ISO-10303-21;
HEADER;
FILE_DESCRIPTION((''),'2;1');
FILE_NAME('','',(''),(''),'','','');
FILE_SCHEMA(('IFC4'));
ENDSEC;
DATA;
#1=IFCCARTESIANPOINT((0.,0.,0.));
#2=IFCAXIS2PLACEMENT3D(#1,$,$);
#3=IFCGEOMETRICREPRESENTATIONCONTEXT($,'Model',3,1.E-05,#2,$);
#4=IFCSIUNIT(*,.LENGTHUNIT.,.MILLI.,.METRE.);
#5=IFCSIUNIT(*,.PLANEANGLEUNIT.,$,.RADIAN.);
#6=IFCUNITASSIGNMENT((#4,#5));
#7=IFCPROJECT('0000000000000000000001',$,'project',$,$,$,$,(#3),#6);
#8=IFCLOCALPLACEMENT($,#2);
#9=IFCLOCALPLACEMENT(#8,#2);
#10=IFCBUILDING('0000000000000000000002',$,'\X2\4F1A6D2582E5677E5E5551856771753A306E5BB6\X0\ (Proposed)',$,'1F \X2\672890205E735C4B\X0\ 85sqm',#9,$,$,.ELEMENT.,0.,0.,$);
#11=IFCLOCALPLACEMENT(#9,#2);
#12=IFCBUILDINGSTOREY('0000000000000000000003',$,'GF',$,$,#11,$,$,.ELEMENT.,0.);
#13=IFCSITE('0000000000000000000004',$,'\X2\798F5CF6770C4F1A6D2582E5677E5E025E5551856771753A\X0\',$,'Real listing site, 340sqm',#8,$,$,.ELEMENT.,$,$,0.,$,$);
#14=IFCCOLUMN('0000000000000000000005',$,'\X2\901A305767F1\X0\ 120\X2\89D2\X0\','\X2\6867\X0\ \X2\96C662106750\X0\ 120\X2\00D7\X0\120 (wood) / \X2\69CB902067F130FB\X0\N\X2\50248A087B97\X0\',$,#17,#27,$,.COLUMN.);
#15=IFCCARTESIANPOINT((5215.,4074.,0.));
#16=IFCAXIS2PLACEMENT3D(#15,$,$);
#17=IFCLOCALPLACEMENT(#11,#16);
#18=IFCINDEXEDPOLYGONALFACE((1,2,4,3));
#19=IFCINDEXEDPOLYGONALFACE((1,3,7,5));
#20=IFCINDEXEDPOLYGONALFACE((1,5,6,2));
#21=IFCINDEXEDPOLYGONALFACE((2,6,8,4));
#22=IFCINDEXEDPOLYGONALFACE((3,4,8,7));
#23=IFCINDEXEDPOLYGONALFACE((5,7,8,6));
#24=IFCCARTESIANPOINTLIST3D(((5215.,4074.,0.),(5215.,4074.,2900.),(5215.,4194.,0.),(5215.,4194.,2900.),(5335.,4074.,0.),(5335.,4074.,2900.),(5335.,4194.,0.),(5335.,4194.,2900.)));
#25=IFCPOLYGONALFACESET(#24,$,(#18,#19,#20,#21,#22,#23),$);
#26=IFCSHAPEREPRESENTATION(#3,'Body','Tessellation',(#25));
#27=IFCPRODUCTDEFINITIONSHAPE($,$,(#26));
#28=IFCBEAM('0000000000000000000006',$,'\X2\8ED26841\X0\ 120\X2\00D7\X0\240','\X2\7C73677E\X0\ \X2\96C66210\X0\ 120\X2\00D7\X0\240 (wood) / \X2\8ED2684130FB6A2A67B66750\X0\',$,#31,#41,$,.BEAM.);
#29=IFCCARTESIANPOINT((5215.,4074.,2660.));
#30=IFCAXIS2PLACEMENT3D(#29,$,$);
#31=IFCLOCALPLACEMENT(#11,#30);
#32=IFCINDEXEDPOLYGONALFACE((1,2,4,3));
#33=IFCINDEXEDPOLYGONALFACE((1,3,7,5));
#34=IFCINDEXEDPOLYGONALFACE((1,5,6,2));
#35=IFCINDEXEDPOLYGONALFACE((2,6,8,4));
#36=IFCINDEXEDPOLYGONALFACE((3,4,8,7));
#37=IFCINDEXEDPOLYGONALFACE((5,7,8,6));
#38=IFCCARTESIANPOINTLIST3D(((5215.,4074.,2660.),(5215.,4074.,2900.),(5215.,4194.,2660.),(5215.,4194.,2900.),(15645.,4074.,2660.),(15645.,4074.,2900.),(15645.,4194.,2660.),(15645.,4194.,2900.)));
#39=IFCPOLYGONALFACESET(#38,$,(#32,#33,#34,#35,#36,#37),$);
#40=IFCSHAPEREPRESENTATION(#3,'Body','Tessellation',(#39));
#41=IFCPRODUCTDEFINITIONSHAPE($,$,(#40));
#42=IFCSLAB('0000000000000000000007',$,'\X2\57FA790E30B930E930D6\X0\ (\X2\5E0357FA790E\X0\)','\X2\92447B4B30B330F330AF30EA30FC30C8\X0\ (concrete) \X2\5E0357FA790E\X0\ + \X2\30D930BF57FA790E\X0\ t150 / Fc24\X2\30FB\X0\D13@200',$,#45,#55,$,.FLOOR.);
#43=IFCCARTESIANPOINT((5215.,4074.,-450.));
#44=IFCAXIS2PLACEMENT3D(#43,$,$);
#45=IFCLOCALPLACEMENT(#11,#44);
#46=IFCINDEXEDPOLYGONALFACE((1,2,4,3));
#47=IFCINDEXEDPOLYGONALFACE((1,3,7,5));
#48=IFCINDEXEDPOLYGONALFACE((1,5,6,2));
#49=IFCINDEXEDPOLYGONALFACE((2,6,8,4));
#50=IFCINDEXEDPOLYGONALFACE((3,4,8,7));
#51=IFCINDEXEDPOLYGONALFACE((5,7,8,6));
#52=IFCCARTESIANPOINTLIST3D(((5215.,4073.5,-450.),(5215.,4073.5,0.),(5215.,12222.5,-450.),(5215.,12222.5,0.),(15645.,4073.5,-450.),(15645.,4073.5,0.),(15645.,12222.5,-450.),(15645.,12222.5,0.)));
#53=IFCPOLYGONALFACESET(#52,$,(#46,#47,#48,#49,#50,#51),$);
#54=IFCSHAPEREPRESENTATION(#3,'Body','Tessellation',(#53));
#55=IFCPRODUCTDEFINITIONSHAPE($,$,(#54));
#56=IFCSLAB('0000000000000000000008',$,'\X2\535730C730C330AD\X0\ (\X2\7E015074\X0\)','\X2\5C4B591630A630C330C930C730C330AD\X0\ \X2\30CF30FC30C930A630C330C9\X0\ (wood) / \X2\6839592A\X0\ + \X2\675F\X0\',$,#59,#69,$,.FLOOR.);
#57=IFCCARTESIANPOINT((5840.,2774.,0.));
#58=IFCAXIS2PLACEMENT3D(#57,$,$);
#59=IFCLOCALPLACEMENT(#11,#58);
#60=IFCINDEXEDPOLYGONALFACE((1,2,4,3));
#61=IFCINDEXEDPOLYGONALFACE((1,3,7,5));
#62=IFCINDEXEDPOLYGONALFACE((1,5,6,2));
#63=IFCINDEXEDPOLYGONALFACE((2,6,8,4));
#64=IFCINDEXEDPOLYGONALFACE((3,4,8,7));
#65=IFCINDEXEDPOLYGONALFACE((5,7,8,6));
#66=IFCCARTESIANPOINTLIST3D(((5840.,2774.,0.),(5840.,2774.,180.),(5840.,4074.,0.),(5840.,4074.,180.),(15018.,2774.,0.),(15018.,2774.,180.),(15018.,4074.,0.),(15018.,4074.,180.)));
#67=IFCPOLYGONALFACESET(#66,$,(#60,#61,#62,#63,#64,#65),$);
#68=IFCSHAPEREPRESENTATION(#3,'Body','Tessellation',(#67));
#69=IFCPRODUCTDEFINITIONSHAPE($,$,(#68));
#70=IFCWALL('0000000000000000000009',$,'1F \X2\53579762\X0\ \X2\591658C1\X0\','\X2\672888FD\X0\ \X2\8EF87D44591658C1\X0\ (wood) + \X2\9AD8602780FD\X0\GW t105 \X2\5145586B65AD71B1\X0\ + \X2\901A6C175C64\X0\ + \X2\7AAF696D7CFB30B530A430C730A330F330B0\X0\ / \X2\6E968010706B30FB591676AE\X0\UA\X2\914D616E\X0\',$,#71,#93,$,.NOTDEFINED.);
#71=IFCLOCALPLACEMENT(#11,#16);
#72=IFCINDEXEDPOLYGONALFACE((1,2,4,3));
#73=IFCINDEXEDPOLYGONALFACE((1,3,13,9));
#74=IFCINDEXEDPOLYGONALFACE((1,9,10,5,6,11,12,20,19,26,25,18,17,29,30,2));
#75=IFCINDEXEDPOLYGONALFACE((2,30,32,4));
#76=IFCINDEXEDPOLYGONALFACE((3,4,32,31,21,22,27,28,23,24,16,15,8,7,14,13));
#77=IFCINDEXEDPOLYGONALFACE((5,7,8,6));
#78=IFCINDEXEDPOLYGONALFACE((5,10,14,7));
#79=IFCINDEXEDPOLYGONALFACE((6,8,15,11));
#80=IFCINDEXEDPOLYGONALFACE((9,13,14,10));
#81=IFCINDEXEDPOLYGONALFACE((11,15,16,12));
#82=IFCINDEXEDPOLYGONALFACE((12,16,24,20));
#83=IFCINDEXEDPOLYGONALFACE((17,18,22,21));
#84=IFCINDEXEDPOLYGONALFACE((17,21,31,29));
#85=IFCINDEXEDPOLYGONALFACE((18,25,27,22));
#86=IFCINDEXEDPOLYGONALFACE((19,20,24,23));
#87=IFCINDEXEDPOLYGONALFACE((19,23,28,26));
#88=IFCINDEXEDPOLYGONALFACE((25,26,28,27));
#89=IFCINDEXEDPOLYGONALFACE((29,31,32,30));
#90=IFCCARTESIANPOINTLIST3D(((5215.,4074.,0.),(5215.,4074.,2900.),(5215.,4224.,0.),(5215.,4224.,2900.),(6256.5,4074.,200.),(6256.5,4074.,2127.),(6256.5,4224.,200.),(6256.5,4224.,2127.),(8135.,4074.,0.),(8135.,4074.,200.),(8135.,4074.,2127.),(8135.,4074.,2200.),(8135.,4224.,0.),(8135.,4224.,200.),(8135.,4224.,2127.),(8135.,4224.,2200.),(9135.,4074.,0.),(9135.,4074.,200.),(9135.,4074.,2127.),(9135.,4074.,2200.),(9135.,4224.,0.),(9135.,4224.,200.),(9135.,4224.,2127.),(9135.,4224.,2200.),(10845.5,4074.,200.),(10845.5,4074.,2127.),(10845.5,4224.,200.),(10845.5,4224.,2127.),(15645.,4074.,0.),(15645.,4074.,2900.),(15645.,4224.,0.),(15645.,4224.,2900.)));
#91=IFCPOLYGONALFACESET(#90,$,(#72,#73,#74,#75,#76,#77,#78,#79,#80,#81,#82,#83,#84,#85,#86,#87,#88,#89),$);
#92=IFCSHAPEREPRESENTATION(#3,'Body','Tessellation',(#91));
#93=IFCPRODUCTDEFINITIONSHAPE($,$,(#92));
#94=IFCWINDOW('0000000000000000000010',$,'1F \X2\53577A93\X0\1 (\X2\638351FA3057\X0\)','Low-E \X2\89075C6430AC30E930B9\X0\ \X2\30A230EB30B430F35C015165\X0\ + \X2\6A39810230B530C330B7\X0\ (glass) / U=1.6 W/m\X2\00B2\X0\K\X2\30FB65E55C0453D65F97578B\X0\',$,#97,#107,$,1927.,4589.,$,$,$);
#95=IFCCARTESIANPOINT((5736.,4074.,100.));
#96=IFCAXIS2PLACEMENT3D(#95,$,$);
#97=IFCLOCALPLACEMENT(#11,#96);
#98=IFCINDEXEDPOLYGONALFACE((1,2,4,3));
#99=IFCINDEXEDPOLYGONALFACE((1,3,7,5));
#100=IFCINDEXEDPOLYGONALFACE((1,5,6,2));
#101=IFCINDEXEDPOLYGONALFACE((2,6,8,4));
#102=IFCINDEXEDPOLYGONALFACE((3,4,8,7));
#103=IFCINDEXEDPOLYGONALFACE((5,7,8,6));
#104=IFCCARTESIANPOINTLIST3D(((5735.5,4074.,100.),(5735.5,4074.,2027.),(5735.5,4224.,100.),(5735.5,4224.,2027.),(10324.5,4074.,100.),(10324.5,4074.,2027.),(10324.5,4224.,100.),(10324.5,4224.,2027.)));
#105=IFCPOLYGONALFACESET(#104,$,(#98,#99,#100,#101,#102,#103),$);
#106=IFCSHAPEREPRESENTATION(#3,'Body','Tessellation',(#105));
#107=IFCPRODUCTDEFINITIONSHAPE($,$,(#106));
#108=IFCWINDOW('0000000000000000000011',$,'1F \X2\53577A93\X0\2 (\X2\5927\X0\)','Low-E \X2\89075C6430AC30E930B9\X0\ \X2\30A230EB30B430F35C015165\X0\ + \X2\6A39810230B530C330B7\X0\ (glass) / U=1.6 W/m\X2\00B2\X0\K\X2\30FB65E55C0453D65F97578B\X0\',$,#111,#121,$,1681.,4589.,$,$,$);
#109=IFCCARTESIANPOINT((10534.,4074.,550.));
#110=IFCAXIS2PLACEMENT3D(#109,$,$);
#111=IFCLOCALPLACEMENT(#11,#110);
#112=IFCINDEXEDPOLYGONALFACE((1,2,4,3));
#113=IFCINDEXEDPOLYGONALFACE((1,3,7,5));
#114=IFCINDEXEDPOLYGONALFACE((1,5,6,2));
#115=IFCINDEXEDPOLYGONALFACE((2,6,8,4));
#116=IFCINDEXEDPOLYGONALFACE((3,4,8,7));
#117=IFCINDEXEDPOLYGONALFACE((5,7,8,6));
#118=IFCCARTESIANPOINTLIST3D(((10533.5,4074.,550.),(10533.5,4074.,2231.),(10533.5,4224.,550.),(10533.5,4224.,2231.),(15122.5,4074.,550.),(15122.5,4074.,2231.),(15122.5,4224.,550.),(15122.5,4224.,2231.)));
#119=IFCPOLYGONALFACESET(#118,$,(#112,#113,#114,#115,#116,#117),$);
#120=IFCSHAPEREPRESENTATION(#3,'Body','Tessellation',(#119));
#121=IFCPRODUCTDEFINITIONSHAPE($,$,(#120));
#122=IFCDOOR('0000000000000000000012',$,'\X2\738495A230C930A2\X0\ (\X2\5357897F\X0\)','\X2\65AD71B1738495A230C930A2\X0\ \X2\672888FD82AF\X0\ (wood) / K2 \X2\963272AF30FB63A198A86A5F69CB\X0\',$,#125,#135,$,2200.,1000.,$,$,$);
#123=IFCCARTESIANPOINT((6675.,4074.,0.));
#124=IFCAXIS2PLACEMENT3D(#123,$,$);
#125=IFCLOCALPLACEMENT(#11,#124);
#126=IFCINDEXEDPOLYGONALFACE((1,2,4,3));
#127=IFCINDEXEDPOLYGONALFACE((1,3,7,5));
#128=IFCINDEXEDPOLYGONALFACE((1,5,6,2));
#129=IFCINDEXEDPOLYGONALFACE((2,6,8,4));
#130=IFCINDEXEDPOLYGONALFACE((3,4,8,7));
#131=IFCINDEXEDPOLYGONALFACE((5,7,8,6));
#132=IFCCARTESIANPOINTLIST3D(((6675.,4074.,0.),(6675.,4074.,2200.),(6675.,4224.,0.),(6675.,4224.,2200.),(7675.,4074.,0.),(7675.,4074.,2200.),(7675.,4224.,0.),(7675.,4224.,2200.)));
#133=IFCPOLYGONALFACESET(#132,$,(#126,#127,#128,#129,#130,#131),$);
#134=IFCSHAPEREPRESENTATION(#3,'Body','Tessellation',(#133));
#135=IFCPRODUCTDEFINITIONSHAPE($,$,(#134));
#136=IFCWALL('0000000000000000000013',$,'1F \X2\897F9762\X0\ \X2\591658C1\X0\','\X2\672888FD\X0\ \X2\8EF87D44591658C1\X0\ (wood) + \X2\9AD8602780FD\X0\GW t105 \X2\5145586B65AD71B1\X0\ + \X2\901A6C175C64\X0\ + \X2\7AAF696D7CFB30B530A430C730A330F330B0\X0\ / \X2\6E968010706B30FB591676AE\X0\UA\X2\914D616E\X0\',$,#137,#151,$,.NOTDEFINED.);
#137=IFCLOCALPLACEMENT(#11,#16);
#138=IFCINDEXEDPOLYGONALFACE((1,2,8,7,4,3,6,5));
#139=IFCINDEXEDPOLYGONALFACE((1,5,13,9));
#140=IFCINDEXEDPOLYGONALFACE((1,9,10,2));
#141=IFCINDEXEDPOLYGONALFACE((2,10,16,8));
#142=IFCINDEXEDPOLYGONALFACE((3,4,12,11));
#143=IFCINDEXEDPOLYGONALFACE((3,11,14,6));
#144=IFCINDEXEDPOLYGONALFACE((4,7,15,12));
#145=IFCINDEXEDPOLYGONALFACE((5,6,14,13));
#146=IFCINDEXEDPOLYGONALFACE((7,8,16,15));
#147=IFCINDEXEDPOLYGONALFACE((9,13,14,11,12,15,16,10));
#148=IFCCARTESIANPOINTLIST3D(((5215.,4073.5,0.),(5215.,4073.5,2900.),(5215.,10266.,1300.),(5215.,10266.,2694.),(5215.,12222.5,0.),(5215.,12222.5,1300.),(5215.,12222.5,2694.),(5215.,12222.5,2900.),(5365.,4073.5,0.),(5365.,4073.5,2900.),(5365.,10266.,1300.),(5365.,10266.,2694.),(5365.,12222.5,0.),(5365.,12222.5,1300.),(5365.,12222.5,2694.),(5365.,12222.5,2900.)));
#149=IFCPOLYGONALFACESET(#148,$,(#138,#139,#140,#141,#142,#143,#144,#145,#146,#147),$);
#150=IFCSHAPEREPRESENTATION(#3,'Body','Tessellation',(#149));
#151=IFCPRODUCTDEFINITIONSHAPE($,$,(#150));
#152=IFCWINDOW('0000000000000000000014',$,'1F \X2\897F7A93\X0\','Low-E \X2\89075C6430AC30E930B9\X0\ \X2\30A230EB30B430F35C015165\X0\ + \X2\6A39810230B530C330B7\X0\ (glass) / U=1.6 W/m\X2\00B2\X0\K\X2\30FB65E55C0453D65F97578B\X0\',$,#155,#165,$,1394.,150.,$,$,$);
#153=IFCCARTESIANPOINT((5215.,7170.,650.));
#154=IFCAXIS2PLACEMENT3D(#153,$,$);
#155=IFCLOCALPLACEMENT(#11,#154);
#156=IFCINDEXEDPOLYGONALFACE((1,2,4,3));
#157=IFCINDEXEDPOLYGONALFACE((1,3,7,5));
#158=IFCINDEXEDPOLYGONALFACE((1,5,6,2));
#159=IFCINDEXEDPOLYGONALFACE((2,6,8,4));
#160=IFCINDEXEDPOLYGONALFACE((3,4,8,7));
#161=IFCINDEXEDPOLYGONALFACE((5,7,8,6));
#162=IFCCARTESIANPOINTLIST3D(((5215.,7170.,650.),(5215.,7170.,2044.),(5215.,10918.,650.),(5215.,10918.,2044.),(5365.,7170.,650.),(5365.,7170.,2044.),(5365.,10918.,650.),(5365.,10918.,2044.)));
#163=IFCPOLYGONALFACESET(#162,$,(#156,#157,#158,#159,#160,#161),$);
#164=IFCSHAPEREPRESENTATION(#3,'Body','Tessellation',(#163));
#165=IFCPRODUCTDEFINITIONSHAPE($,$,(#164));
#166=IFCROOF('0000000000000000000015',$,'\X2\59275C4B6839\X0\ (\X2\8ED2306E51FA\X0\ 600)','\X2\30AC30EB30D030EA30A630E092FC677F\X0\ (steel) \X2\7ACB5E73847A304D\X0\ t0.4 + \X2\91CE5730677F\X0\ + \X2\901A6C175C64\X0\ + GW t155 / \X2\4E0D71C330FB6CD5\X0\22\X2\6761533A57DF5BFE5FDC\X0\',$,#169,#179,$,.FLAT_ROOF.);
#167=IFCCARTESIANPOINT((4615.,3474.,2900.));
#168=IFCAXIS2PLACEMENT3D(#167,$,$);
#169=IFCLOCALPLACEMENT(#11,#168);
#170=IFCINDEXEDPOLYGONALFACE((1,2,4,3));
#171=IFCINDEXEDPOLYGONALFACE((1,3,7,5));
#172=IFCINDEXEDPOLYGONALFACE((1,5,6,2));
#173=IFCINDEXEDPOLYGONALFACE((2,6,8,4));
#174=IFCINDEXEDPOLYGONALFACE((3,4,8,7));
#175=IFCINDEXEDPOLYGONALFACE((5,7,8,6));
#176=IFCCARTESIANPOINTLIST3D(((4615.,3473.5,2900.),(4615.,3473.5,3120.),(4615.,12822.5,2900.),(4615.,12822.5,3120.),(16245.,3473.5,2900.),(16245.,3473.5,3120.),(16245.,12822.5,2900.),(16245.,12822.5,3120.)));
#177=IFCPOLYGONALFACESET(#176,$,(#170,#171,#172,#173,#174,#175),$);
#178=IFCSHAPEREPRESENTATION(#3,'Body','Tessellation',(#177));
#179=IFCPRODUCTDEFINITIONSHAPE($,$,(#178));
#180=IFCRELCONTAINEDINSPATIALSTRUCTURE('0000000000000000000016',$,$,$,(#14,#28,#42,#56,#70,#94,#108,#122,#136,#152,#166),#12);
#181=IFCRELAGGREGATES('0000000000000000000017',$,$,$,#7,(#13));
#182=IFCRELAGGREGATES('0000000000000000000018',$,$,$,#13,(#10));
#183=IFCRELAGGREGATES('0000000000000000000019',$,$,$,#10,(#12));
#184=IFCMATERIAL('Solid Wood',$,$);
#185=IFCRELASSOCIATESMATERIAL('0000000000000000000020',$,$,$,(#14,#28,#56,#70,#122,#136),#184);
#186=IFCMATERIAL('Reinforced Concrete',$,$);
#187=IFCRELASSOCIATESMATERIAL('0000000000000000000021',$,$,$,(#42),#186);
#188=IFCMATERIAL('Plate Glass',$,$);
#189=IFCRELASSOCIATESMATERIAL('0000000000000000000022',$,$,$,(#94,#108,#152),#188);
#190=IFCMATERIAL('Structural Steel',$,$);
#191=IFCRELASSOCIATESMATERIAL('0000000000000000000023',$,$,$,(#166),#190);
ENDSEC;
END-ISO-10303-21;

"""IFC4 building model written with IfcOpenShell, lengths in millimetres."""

from ifc_helpers import new_model, si_unit, frame, frame_2d, origin, place, context, project, spatial, rectangle, extrude, material, element, fill, save


model = new_model("IFC4")

# Units and contexts
model_context = context("Model", 3, precision=1e-05, world=origin())
ifc_project = project(units=[si_unit("LENGTHUNIT", "METRE", prefix="MILLI"), si_unit("PLANEANGLEUNIT", "RADIAN")], contexts=[model_context])

# Site, building, storey
site_placement = place(None, origin())
site = spatial("IfcSite", under=ifc_project, at=site_placement, Name="福島県会津若松市幕内東町", ObjectType="Real listing site, 340sqm", CompositionType="ELEMENT", RefElevation=0.0)
building_placement = place(site_placement, origin())
building = spatial("IfcBuilding", under=site, at=building_placement, Name="会津若松幕内東町の家 (Proposed)", ObjectType="1F 木造平屋 85sqm", CompositionType="ELEMENT", ElevationOfRefHeight=0.0, ElevationOfTerrain=0.0)
storey_placement = place(building_placement, origin())
storey = spatial("IfcBuildingStorey", under=building, at=storey_placement, Name="GF", CompositionType="ELEMENT", Elevation=0.0)

# Column
ifc_material_1 = material(Name="Solid Wood")
column_1_placement = place(storey_placement, frame((5215.0, 4074.0, 0.0)))
element("IfcColumn", 1, at=column_1_placement, inside=storey, material=ifc_material_1, Name="通し柱 120角", Description="桧 集成材 120×120 (wood) / 構造柱・N値計算", PredefinedType="COLUMN", context=model_context, shape_type="SweptSolid", body=[
    extrude(rectangle(XDim=120.0, YDim=120.0, at=frame_2d((60.0, 60.0))), frame((5215.0, 4074.0, 0.0)), (0.0, 0.0, 1.0), 2900.0),
])

# Beam
beam_1_placement = place(storey_placement, frame((5215.0, 4074.0, 2660.0)))
element("IfcBeam", 2, at=beam_1_placement, inside=storey, material=ifc_material_1, Name="軒桁 120×240", Description="米松 集成 120×240 (wood) / 軒桁・横架材", PredefinedType="BEAM", context=model_context, shape_type="SweptSolid", body=[
    extrude(rectangle(XDim=10430.0, YDim=120.0, at=frame_2d((5215.0, 60.0))), frame((5215.0, 4074.0, 2660.0)), (0.0, 0.0, 1.0), 240.0),
])

# Slabs
ifc_material_2 = material(Name="Reinforced Concrete")
slab_1_placement = place(storey_placement, frame((5215.0, 4074.0, -450.0)))
element("IfcSlab", 3, at=slab_1_placement, inside=storey, material=ifc_material_2, Name="基礎スラブ (布基礎)", Description="鉄筋コンクリート (concrete) 布基礎 + ベタ基礎 t150 / Fc24・D13@200", PredefinedType="FLOOR", context=model_context, shape_type="SweptSolid", body=[
    extrude(rectangle(XDim=10430.0, YDim=8149.0, at=frame_2d((5215.0, 4074.0))), frame((5215.0, 4074.0, -450.0)), (0.0, 0.0, 1.0), 450.0),
])
slab_2_placement = place(storey_placement, frame((5840.0, 2774.0, 0.0)))
element("IfcSlab", 4, at=slab_2_placement, inside=storey, material=ifc_material_1, Name="南デッキ (縁側)", Description="屋外ウッドデッキ ハードウッド (wood) / 根太 + 束", PredefinedType="FLOOR", context=model_context, shape_type="SweptSolid", body=[
    extrude(rectangle(XDim=9178.0, YDim=1300.0, at=frame_2d((4589.0, 650.0))), frame((5840.0, 2774.0, 0.0)), (0.0, 0.0, 1.0), 180.0),
])

# Wall, openings, windows, door
wall_1_placement = place(storey_placement, frame((5215.0, 4074.0, 0.0)))
wall_1 = element("IfcWall", 5, at=wall_1_placement, inside=storey, material=ifc_material_1, Name="1F 南面 外壁", Description="木製 軸組外壁 (wood) + 高性能GW t105 充填断熱 + 通気層 + 窯業系サイディング / 準耐火・外皮UA配慮", PredefinedType="NOTDEFINED", context=model_context, shape_type="SweptSolid", body=[
    extrude(rectangle(XDim=10430.0, YDim=150.0, at=frame_2d((5215.0, 75.0))), frame((5215.0, 4074.0, 0.0)), (0.0, 0.0, 1.0), 2900.0),
])
opening_1_placement = place(storey_placement, frame((5736.0, 4074.0, 100.0)))
opening_1 = element("IfcOpeningElement", 6, at=opening_1_placement, cuts=wall_1, PredefinedType="NOTDEFINED", context=model_context, shape_type="SweptSolid", body=[
    extrude(rectangle(XDim=4589.0, YDim=150.0, at=frame_2d((2294.0, 75.0))), frame((5736.0, 4074.0, 100.0)), (0.0, 0.0, 1.0), 1927.0),
])
opening_2_placement = place(storey_placement, frame((10534.0, 4074.0, 550.0)))
opening_2 = element("IfcOpeningElement", 7, at=opening_2_placement, cuts=wall_1, PredefinedType="NOTDEFINED", context=model_context, shape_type="SweptSolid", body=[
    extrude(rectangle(XDim=4589.0, YDim=150.0, at=frame_2d((2294.0, 75.0))), frame((10534.0, 4074.0, 550.0)), (0.0, 0.0, 1.0), 1681.0),
])
opening_3_placement = place(storey_placement, frame((6675.0, 4074.0, 0.0)))
opening_3 = element("IfcOpeningElement", 8, at=opening_3_placement, cuts=wall_1, PredefinedType="NOTDEFINED", context=model_context, shape_type="SweptSolid", body=[
    extrude(rectangle(XDim=1000.0, YDim=150.0, at=frame_2d((500.0, 75.0))), frame((6675.0, 4074.0, 0.0)), (0.0, 0.0, 1.0), 2200.0),
])
ifc_material_3 = material(Name="Plate Glass")
window_1_placement = place(storey_placement, frame((5736.0, 4074.0, 100.0)))
window_1 = element("IfcWindow", 9, at=window_1_placement, inside=storey, material=ifc_material_3, Name="1F 南窓1 (掃出し)", Description="Low-E 複層ガラス アルゴン封入 + 樹脂サッシ (glass) / U=1.6 W/m²K・日射取得型", OverallHeight=1927.0, OverallWidth=4589.0, context=model_context, shape_type="SweptSolid", body=[
    extrude(rectangle(XDim=4589.0, YDim=150.0, at=frame_2d((2294.0, 75.0))), frame((5736.0, 4074.0, 100.0)), (0.0, 0.0, 1.0), 1927.0),
])
fill(opening_1, window_1)
window_2_placement = place(storey_placement, frame((10534.0, 4074.0, 550.0)))
window_2 = element("IfcWindow", 10, at=window_2_placement, inside=storey, material=ifc_material_3, Name="1F 南窓2 (大)", Description="Low-E 複層ガラス アルゴン封入 + 樹脂サッシ (glass) / U=1.6 W/m²K・日射取得型", OverallHeight=1681.0, OverallWidth=4589.0, context=model_context, shape_type="SweptSolid", body=[
    extrude(rectangle(XDim=4589.0, YDim=150.0, at=frame_2d((2294.0, 75.0))), frame((10534.0, 4074.0, 550.0)), (0.0, 0.0, 1.0), 1681.0),
])
fill(opening_2, window_2)
door_placement = place(storey_placement, frame((6675.0, 4074.0, 0.0)))
door = element("IfcDoor", 11, at=door_placement, inside=storey, material=ifc_material_1, Name="玄関ドア (南西)", Description="断熱玄関ドア 木製芯 (wood) / K2 防犯・採風機構", OverallHeight=2200.0, OverallWidth=1000.0, context=model_context, shape_type="SweptSolid", body=[
    extrude(rectangle(XDim=1000.0, YDim=150.0, at=frame_2d((500.0, 75.0))), frame((6675.0, 4074.0, 0.0)), (0.0, 0.0, 1.0), 2200.0),
])
fill(opening_3, door)

# Wall, opening, window
wall_2_placement = place(storey_placement, frame((5215.0, 4074.0, 0.0)))
wall_2 = element("IfcWall", 12, at=wall_2_placement, inside=storey, material=ifc_material_1, Name="1F 西面 外壁", Description="木製 軸組外壁 (wood) + 高性能GW t105 充填断熱 + 通気層 + 窯業系サイディング / 準耐火・外皮UA配慮", PredefinedType="NOTDEFINED", context=model_context, shape_type="SweptSolid", body=[
    extrude(rectangle(XDim=150.0, YDim=8149.0, at=frame_2d((75.0, 4074.0))), frame((5215.0, 4074.0, 0.0)), (0.0, 0.0, 1.0), 2900.0),
])
opening_4_placement = place(storey_placement, frame((5215.0, 7170.0, 650.0)))
opening_4 = element("IfcOpeningElement", 13, at=opening_4_placement, cuts=wall_2, PredefinedType="NOTDEFINED", context=model_context, shape_type="SweptSolid", body=[
    extrude(rectangle(XDim=150.0, YDim=3748.0, at=frame_2d((75.0, 1874.0))), frame((5215.0, 7170.0, 650.0)), (0.0, 0.0, 1.0), 1394.0),
])
window_3_placement = place(storey_placement, frame((5215.0, 7170.0, 650.0)))
window_3 = element("IfcWindow", 14, at=window_3_placement, inside=storey, material=ifc_material_3, Name="1F 西窓", Description="Low-E 複層ガラス アルゴン封入 + 樹脂サッシ (glass) / U=1.6 W/m²K・日射取得型", OverallHeight=1394.0, OverallWidth=150.0, context=model_context, shape_type="SweptSolid", body=[
    extrude(rectangle(XDim=150.0, YDim=3748.0, at=frame_2d((75.0, 1874.0))), frame((5215.0, 7170.0, 650.0)), (0.0, 0.0, 1.0), 1394.0),
])
fill(opening_4, window_3)

# Roof
ifc_material_4 = material(Name="Structural Steel")
roof_placement = place(storey_placement, frame((4615.0, 3474.0, 2900.0)))
element("IfcRoof", 15, at=roof_placement, inside=storey, material=ifc_material_4, Name="大屋根 (軒の出 600)", Description="ガルバリウム鋼板 (steel) 立平葺き t0.4 + 野地板 + 通気層 + GW t155 / 不燃・法22条区域対応", PredefinedType="FLAT_ROOF", context=model_context, shape_type="SweptSolid", body=[
    extrude(rectangle(XDim=11630.0, YDim=9349.0, at=frame_2d((5815.0, 4674.0))), frame((4615.0, 3474.0, 2900.0)), (0.0, 0.0, 1.0), 220.0),
])

save(model, "model.ifc")
